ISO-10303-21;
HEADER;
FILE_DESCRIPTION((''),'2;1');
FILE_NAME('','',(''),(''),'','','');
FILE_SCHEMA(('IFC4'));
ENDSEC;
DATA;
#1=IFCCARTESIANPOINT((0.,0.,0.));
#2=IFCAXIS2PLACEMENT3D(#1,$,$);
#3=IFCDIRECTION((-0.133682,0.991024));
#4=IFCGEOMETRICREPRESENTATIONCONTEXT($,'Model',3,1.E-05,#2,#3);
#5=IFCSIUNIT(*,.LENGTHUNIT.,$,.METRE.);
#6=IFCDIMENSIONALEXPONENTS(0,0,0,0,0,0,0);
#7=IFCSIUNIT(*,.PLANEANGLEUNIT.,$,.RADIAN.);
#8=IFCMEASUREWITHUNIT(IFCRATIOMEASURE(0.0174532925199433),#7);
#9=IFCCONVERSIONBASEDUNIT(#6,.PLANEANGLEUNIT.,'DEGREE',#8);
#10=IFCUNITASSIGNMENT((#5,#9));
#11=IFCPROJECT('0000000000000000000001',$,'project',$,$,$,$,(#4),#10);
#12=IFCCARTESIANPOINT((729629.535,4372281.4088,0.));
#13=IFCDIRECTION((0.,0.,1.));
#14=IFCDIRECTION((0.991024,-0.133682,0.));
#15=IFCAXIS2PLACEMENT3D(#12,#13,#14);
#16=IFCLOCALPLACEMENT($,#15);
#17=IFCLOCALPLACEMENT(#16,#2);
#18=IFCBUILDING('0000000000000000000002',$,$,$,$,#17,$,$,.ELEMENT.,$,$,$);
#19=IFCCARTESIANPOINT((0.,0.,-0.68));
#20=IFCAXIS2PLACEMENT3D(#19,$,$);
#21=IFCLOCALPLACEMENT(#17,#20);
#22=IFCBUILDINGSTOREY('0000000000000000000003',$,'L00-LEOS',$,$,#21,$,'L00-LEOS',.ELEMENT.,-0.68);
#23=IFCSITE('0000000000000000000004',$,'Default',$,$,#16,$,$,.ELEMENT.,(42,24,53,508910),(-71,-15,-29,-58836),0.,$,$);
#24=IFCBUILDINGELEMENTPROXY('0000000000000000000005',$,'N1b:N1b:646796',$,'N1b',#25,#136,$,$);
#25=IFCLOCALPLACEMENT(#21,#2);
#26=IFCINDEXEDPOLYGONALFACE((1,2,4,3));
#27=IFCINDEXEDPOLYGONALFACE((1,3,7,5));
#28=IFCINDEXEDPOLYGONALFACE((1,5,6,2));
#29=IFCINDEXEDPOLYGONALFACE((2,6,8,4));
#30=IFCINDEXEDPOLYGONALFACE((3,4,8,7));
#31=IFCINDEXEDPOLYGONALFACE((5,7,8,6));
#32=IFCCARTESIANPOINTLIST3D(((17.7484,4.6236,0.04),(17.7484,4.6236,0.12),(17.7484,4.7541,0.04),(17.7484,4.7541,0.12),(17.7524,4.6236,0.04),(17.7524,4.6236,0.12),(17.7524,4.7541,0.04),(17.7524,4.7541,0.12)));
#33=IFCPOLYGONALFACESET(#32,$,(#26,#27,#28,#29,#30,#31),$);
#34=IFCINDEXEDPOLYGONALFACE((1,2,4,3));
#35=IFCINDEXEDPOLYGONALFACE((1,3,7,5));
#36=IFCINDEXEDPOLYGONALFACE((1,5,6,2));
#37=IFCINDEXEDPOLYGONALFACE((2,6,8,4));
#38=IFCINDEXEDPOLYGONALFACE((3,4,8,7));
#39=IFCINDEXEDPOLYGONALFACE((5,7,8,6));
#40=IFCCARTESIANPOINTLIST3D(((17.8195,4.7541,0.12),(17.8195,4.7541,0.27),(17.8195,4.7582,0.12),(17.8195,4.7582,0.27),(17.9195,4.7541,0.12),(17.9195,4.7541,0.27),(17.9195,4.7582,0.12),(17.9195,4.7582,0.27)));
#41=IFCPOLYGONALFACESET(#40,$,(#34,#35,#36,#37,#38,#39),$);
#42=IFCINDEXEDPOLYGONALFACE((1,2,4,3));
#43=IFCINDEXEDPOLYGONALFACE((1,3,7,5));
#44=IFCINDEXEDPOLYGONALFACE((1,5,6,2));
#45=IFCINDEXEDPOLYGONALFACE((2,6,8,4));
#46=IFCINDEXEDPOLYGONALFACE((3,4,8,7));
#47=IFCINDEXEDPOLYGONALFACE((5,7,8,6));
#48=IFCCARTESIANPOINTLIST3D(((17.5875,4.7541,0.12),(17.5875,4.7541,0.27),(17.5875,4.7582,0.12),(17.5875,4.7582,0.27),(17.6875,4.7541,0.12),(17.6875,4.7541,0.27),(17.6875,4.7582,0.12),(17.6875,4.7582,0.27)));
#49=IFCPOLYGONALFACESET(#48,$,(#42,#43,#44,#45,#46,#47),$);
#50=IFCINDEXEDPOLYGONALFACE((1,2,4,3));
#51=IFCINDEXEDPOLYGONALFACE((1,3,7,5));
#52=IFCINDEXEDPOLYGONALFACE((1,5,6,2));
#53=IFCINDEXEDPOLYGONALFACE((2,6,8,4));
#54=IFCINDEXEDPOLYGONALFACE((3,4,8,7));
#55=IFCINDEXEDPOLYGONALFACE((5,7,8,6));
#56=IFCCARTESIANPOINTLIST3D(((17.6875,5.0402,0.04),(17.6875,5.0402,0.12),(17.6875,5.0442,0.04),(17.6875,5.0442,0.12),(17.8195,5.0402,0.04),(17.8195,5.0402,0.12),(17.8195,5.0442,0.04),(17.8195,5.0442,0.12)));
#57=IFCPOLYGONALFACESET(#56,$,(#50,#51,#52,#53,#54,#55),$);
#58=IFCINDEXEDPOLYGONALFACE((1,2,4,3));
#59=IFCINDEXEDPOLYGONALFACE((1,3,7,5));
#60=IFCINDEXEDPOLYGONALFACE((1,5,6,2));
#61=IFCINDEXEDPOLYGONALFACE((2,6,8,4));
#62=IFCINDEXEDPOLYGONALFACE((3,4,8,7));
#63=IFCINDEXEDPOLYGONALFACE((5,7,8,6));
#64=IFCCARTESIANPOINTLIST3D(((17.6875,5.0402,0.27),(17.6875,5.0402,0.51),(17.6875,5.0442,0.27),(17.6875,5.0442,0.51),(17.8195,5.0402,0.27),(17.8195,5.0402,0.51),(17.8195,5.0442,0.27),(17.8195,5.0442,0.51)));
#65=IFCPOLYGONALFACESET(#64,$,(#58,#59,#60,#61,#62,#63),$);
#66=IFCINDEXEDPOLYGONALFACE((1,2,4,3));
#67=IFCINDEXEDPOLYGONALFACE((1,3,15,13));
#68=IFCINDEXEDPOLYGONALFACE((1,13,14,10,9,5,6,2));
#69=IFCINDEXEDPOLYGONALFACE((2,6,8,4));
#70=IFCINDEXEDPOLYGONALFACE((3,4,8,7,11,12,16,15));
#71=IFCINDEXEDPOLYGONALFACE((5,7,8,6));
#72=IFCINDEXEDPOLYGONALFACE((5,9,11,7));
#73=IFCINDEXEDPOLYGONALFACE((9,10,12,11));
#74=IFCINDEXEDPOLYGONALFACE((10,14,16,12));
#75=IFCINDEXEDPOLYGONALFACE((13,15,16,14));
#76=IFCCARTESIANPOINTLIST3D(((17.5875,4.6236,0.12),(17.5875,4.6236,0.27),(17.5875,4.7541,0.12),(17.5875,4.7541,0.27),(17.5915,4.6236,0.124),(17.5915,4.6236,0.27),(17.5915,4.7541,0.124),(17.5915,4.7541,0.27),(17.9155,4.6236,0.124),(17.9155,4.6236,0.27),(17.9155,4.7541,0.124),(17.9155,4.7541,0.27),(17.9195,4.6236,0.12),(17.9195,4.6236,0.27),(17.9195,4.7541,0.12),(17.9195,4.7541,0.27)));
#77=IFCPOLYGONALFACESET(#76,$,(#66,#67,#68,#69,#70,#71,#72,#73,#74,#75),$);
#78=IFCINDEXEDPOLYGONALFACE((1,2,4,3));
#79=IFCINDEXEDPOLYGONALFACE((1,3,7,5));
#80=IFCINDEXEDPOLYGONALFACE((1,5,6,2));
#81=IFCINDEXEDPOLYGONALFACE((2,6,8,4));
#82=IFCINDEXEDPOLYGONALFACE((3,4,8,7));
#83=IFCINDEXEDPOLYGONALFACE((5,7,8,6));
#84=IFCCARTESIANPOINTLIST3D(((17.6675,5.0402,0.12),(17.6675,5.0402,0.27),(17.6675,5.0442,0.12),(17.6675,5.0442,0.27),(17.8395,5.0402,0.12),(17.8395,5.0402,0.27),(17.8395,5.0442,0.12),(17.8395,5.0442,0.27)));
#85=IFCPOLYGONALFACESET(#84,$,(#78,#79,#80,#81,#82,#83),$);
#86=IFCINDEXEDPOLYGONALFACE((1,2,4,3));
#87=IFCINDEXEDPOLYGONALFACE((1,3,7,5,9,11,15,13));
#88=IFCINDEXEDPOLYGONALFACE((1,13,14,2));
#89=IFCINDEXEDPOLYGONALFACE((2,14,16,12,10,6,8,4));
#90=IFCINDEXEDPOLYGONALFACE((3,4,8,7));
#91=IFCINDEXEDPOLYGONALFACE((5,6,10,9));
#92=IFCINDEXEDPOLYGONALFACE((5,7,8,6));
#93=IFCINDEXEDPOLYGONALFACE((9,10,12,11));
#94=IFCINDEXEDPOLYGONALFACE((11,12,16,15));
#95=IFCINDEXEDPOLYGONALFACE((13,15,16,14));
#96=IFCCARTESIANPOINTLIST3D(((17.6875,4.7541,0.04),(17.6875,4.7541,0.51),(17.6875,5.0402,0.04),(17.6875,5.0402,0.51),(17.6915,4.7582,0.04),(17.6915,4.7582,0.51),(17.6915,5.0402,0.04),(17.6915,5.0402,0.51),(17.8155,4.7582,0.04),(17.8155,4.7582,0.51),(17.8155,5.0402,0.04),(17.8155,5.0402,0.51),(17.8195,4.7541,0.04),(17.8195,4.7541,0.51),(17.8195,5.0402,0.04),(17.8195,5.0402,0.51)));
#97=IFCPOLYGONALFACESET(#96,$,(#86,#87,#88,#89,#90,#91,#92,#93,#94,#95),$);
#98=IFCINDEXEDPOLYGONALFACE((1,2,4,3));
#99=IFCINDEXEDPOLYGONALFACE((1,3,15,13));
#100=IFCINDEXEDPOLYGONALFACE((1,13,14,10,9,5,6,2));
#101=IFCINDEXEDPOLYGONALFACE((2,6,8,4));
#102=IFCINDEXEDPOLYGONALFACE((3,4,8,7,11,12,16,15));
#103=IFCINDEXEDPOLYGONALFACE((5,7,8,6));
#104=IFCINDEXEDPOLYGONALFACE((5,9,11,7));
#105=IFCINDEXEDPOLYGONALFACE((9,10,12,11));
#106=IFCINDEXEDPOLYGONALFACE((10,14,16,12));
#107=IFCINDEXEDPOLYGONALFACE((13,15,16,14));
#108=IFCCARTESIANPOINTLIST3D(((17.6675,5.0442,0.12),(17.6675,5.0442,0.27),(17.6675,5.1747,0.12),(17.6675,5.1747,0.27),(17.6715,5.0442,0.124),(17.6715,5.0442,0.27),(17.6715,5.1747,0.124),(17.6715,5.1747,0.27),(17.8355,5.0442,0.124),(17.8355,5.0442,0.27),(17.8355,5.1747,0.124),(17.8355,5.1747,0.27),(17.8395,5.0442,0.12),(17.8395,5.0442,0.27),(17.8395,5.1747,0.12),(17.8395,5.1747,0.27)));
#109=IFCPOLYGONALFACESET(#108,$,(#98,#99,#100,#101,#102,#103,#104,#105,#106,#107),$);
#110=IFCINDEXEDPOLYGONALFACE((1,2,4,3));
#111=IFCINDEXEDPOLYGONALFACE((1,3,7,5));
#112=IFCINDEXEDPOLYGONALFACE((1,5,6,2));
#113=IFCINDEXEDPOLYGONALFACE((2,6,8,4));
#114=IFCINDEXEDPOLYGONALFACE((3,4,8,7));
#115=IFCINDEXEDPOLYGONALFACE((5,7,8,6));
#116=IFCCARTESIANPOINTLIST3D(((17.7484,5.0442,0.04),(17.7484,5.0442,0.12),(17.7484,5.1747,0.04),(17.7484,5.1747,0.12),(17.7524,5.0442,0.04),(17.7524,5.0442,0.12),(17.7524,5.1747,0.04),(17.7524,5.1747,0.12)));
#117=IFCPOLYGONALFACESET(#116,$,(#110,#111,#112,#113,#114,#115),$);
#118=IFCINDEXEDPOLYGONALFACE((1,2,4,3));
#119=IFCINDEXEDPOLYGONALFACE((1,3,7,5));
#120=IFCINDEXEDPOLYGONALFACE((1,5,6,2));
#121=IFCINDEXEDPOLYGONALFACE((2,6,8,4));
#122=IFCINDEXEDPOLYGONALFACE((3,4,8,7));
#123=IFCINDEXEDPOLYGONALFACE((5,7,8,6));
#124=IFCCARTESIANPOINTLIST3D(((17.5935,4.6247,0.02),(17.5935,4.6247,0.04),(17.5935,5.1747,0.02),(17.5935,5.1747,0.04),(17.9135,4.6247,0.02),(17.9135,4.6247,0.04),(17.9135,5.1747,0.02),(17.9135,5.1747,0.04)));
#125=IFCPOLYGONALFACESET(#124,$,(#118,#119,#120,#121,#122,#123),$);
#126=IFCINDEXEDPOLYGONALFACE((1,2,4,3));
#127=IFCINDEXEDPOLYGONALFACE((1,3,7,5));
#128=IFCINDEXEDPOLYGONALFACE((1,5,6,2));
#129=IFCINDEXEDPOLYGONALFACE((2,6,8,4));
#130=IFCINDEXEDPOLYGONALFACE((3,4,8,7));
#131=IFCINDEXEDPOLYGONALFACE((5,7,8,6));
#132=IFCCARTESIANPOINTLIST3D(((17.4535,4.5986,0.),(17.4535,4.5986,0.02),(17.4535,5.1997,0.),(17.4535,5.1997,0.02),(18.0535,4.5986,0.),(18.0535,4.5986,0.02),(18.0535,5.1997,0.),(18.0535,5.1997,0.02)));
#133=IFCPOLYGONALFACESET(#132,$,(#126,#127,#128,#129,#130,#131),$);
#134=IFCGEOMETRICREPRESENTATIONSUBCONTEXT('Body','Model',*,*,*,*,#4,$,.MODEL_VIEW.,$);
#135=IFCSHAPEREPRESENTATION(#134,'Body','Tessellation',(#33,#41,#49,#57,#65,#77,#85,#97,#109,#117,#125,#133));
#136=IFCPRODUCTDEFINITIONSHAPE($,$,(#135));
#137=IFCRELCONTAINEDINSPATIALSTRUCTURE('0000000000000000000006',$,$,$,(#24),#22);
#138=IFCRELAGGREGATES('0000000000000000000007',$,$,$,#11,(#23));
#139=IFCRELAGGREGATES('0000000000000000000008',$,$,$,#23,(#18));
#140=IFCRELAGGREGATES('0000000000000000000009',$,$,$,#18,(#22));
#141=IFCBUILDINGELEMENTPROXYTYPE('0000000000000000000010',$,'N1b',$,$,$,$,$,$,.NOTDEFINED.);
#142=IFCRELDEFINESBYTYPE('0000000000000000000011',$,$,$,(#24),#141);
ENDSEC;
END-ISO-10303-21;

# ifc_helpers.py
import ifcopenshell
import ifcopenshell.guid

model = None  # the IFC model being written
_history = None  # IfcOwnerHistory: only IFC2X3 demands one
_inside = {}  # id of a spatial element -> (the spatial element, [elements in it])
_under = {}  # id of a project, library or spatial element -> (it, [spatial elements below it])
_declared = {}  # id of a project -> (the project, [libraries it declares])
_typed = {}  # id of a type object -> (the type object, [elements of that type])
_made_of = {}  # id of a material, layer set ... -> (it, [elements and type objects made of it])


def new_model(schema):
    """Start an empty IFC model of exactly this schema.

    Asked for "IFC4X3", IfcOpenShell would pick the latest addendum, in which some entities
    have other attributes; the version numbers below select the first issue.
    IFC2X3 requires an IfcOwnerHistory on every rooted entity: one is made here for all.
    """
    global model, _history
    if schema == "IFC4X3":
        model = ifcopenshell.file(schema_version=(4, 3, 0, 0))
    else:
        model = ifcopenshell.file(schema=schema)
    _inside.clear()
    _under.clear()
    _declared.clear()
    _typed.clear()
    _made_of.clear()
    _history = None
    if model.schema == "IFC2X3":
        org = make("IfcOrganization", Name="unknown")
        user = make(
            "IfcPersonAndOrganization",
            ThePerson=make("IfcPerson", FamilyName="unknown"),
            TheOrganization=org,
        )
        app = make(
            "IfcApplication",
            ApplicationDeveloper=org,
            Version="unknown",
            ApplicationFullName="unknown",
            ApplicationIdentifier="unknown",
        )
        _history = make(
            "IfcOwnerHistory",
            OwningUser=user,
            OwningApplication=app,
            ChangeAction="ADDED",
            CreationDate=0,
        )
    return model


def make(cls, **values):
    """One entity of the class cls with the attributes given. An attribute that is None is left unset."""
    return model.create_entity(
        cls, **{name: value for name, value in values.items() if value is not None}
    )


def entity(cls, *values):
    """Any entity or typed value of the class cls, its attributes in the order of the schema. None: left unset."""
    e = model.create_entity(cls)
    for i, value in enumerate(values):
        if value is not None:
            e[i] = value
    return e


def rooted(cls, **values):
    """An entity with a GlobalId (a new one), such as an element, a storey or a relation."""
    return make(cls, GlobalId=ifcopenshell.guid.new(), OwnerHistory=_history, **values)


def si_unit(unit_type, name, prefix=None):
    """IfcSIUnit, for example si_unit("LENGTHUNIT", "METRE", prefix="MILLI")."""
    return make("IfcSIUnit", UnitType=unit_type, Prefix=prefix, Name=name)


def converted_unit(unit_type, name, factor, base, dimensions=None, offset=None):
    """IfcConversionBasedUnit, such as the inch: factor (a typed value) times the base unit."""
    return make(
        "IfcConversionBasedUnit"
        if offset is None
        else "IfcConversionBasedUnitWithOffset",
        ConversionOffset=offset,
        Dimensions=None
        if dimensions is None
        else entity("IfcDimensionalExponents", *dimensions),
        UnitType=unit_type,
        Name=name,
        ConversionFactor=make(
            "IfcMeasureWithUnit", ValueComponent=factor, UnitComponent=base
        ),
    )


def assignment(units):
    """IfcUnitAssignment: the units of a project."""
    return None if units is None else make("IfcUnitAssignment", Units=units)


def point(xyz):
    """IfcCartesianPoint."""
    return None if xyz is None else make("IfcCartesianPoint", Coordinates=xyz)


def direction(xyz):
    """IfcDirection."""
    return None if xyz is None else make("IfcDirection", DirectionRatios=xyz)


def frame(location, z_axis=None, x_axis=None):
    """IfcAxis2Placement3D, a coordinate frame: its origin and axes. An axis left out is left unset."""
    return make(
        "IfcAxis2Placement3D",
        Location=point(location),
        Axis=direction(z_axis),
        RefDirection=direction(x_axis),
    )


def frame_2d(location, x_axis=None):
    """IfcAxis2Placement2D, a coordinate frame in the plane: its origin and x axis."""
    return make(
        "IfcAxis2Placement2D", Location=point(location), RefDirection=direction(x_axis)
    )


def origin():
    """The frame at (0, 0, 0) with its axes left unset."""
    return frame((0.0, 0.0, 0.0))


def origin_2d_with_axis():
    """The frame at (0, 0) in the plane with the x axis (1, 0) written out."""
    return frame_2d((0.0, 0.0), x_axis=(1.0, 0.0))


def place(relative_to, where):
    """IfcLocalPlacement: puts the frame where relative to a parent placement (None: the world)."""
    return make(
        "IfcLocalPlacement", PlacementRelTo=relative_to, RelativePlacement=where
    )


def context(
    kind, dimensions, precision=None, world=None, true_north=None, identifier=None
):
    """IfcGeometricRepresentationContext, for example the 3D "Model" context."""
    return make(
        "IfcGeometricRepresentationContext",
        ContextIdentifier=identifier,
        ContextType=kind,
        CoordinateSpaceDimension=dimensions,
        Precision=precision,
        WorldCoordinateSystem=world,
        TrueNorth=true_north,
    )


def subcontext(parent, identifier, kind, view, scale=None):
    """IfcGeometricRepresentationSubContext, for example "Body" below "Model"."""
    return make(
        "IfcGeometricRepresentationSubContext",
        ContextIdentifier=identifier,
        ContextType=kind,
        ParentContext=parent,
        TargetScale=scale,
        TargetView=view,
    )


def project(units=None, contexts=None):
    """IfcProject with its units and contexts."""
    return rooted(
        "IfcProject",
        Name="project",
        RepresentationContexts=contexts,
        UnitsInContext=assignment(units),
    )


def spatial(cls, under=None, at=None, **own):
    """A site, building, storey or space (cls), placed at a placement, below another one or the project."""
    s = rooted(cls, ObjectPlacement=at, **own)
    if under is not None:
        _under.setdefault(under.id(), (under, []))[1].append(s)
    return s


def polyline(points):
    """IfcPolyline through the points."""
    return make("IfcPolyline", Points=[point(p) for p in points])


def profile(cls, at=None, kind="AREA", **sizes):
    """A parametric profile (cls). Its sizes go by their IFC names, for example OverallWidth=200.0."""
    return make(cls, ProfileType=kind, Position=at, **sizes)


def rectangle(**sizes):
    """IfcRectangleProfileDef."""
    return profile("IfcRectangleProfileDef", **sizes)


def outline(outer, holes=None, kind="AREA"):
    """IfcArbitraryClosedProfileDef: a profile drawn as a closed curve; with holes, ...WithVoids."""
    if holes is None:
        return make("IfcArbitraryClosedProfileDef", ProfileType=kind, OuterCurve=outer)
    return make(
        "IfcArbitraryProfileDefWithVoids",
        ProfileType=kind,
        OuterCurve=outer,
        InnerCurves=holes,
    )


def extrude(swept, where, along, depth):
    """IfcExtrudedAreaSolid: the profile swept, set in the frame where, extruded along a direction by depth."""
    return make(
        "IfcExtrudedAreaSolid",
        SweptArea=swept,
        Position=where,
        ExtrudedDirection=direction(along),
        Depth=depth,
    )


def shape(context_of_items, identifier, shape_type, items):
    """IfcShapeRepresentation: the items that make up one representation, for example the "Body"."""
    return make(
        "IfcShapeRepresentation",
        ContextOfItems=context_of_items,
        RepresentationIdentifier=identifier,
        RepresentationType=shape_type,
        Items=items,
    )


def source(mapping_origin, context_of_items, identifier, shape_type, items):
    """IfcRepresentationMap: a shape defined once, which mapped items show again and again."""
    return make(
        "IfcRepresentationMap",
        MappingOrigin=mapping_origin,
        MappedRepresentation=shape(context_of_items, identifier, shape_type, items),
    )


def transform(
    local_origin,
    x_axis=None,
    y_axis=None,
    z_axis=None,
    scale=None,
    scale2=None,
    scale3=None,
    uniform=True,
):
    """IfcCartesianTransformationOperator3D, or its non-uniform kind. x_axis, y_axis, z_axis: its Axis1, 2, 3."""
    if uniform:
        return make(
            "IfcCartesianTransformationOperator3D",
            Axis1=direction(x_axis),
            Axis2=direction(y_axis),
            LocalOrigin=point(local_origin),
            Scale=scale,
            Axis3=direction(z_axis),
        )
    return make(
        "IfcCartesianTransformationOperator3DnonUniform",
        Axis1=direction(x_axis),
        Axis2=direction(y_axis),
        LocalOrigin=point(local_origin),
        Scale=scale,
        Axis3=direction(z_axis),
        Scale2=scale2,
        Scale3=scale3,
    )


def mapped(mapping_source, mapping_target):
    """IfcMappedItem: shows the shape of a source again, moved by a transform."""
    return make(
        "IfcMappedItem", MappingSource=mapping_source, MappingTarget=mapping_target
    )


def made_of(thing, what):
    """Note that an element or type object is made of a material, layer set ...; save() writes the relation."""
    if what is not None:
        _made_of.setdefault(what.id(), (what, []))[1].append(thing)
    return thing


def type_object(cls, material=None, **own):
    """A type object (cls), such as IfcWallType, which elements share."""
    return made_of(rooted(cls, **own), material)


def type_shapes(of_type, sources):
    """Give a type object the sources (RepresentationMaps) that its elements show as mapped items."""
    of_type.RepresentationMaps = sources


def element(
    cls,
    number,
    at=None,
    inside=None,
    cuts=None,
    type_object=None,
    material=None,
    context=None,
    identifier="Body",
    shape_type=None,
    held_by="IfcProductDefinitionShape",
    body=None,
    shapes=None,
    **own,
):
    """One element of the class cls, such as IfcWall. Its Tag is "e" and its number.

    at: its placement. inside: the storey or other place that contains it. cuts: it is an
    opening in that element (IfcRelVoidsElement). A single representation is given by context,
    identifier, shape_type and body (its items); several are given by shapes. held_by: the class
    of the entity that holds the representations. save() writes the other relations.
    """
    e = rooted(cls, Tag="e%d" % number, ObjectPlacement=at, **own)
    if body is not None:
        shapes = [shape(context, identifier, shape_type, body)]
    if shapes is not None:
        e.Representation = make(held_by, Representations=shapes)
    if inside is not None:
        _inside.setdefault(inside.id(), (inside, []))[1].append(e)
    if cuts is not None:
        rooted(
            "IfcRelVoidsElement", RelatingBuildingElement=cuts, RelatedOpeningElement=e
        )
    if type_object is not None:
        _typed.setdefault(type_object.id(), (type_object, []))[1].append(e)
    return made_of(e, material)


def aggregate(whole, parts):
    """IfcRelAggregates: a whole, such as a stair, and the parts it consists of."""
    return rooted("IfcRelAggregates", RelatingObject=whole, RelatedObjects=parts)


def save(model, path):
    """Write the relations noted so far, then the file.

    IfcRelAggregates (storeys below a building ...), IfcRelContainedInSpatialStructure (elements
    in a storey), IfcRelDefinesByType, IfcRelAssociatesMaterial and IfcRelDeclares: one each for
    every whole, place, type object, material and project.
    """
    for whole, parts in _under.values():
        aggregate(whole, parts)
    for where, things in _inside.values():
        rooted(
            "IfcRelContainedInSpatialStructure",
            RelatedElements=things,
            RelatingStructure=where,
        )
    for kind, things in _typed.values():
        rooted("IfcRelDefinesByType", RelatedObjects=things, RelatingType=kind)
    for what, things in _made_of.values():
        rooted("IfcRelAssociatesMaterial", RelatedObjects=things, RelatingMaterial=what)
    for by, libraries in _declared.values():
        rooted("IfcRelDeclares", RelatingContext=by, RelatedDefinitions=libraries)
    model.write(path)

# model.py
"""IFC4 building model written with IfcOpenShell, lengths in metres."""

from ifc_helpers import new_model, entity, si_unit, converted_unit, direction, frame, frame_2d, origin, origin_2d_with_axis, place, context, subcontext, project, spatial, polyline, rectangle, outline, extrude, source, transform, mapped, type_object, type_shapes, element, save


model = new_model("IFC4")

# Units and contexts
model_context = context("Model", 3, precision=1e-05, world=origin(), true_north=direction((-0.133682, 0.991024)))
body_context = subcontext(model_context, "Body", "Model", "MODEL_VIEW")
ifc_project = project(units=[si_unit("LENGTHUNIT", "METRE"), converted_unit("PLANEANGLEUNIT", "DEGREE", entity("IfcRatioMeasure", 0.0174532925199433), si_unit("PLANEANGLEUNIT", "RADIAN"), dimensions=[0, 0, 0, 0, 0, 0, 0])], contexts=[model_context])

# Site, building, storey
site_placement = place(None, frame((729629.535, 4372281.4088, 0.0), z_axis=(0.0, 0.0, 1.0), x_axis=(0.991024, -0.133682, 0.0)))
site = spatial("IfcSite", under=ifc_project, at=site_placement, Name="Default", CompositionType="ELEMENT", RefLatitude=(42, 24, 53, 508910), RefLongitude=(-71, -15, -29, -58836), RefElevation=0.0)
building_placement = place(site_placement, origin())
building = spatial("IfcBuilding", under=site, at=building_placement, CompositionType="ELEMENT")
storey_placement = place(building_placement, frame((0.0, 0.0, -0.68)))
storey = spatial("IfcBuildingStorey", under=building, at=storey_placement, Name="L00-LEOS", LongName="L00-LEOS", CompositionType="ELEMENT", Elevation=-0.68)

# Building element proxy
building_element_proxy_type_1 = type_object("IfcBuildingElementProxyType", Name="N1b")
shared_shape_1 = source(origin(), body_context, "Body", "SweptSolid", [
    extrude(rectangle(XDim=0.004, YDim=0.1305, at=origin_2d_with_axis()), frame((0.2103, 0.0, 0.04), z_axis=(0.0, 0.0, 1.0), x_axis=(0.0, -1.0, 0.0)), (0.0, 0.0, 1.0), 0.08),
    extrude(rectangle(XDim=0.1, YDim=0.0042, at=frame_2d((0.0, 0.0), x_axis=(1.0, 0.0))), frame((0.143, 0.1191, 0.12), z_axis=(0.0, 0.0, 1.0), x_axis=(0.0, 1.0, 0.0)), (0.0, 0.0, 1.0), 0.15),
    extrude(rectangle(XDim=0.1, YDim=0.0042, at=origin_2d_with_axis()), frame((0.143, -0.1129, 0.12), z_axis=(0.0, 0.0, 1.0), x_axis=(0.0, 1.0, 0.0)), (0.0, 0.0, 1.0), 0.15),
    extrude(rectangle(XDim=0.132, YDim=0.004, at=frame_2d((0.0, 0.0), x_axis=(1.0, 0.0))), frame((-0.1431, 0.0031, 0.04), z_axis=(0.0, 0.0, 1.0), x_axis=(0.0, 1.0, 0.0)), (0.0, 0.0, 1.0), 0.08),
    extrude(rectangle(XDim=0.132, YDim=0.004, at=frame_2d((0.0, 0.0), x_axis=(1.0, 0.0))), frame((-0.1431, 0.0031, 0.27), z_axis=(0.0, 0.0, 1.0), x_axis=(0.0, 1.0, 0.0)), (0.0, 0.0, 1.0), 0.24),
    extrude(outline(polyline([(-0.076, -0.166), (0.074, -0.166), (0.074, -0.162), (-0.072, -0.162), (-0.072, 0.162), (0.074, 0.162), (0.074, 0.166), (-0.076, 0.166), (-0.076, -0.166)])), frame((0.1451, 0.0031, 0.196), z_axis=(1.0, 0.0, 0.0), x_axis=(0.0, 0.0, 1.0)), (0.0, 0.0, 1.0), 0.1305),
    extrude(rectangle(XDim=0.172, YDim=0.004, at=frame_2d((0.0, 0.0), x_axis=(1.0, 0.0))), frame((-0.1431, 0.0031, 0.12), z_axis=(0.0, 0.0, 1.0), x_axis=(0.0, 1.0, 0.0)), (0.0, 0.0, 1.0), 0.15),
    extrude(outline(polyline([(-0.1441, -0.066), (0.142, -0.066), (0.142, -0.062), (-0.14, -0.062), (-0.14, 0.062), (0.142, 0.062), (0.142, 0.066), (-0.1441, 0.066), (-0.1441, -0.066)])), frame((0.001, 0.0031, 0.04), z_axis=(0.0, 0.0, 1.0), x_axis=(-1.0, 0.0, 0.0)), (0.0, 0.0, 1.0), 0.47),
    extrude(outline(polyline([(-0.076, -0.086), (0.074, -0.086), (0.074, -0.082), (-0.072, -0.082), (-0.072, 0.082), (0.074, 0.082), (0.074, 0.086), (-0.076, 0.086), (-0.076, -0.086)])), frame((-0.2756, 0.0031, 0.196), z_axis=(1.0, 0.0, 0.0), x_axis=(0.0, 0.0, 1.0)), (0.0, 0.0, 1.0), 0.1305),
    extrude(rectangle(XDim=0.004, YDim=0.1305, at=origin_2d_with_axis()), frame((-0.2103, 0.0, 0.04), z_axis=(0.0, 0.0, 1.0), x_axis=(0.0, -1.0, 0.0)), (0.0, 0.0, 1.0), 0.08),
    extrude(rectangle(XDim=0.55, YDim=0.32, at=frame_2d((0.0, 0.0), x_axis=(1.0, 0.0))), frame((-0.0006, 0.0031, 0.02), z_axis=(0.0, 0.0, 1.0), x_axis=(-1.0, 0.0, 0.0)), (0.0, 0.0, 1.0), 0.02),
    extrude(rectangle(XDim=0.6012, YDim=0.6, at=frame_2d((0.0, 0.0), x_axis=(1.0, 0.0))), frame((0.0, 0.0031, 0.0), z_axis=(0.0, 0.0, 1.0), x_axis=(-1.0, 0.0, 0.0)), (0.0, 0.0, 1.0), 0.02),
])
type_shapes(building_element_proxy_type_1, [shared_shape_1])
for number, where, z_axis, x_axis, name in (
    (1, (17.7504, 4.8991, 0.0), (0.0, 0.0, 1.0), (0.0, -1.0, 0.0), "N1b:N1b:646796"),
):
    element("IfcBuildingElementProxy", number, at=place(storey_placement, frame(where, z_axis=z_axis, x_axis=x_axis)), inside=storey, type_object=building_element_proxy_type_1, Name=name, ObjectType="N1b", context=body_context, shape_type="MappedRepresentation", body=[
        mapped(shared_shape_1, transform((0.0, 0.0, 0.0), scale=1.0)),
    ])

save(model, "model.ifc")
